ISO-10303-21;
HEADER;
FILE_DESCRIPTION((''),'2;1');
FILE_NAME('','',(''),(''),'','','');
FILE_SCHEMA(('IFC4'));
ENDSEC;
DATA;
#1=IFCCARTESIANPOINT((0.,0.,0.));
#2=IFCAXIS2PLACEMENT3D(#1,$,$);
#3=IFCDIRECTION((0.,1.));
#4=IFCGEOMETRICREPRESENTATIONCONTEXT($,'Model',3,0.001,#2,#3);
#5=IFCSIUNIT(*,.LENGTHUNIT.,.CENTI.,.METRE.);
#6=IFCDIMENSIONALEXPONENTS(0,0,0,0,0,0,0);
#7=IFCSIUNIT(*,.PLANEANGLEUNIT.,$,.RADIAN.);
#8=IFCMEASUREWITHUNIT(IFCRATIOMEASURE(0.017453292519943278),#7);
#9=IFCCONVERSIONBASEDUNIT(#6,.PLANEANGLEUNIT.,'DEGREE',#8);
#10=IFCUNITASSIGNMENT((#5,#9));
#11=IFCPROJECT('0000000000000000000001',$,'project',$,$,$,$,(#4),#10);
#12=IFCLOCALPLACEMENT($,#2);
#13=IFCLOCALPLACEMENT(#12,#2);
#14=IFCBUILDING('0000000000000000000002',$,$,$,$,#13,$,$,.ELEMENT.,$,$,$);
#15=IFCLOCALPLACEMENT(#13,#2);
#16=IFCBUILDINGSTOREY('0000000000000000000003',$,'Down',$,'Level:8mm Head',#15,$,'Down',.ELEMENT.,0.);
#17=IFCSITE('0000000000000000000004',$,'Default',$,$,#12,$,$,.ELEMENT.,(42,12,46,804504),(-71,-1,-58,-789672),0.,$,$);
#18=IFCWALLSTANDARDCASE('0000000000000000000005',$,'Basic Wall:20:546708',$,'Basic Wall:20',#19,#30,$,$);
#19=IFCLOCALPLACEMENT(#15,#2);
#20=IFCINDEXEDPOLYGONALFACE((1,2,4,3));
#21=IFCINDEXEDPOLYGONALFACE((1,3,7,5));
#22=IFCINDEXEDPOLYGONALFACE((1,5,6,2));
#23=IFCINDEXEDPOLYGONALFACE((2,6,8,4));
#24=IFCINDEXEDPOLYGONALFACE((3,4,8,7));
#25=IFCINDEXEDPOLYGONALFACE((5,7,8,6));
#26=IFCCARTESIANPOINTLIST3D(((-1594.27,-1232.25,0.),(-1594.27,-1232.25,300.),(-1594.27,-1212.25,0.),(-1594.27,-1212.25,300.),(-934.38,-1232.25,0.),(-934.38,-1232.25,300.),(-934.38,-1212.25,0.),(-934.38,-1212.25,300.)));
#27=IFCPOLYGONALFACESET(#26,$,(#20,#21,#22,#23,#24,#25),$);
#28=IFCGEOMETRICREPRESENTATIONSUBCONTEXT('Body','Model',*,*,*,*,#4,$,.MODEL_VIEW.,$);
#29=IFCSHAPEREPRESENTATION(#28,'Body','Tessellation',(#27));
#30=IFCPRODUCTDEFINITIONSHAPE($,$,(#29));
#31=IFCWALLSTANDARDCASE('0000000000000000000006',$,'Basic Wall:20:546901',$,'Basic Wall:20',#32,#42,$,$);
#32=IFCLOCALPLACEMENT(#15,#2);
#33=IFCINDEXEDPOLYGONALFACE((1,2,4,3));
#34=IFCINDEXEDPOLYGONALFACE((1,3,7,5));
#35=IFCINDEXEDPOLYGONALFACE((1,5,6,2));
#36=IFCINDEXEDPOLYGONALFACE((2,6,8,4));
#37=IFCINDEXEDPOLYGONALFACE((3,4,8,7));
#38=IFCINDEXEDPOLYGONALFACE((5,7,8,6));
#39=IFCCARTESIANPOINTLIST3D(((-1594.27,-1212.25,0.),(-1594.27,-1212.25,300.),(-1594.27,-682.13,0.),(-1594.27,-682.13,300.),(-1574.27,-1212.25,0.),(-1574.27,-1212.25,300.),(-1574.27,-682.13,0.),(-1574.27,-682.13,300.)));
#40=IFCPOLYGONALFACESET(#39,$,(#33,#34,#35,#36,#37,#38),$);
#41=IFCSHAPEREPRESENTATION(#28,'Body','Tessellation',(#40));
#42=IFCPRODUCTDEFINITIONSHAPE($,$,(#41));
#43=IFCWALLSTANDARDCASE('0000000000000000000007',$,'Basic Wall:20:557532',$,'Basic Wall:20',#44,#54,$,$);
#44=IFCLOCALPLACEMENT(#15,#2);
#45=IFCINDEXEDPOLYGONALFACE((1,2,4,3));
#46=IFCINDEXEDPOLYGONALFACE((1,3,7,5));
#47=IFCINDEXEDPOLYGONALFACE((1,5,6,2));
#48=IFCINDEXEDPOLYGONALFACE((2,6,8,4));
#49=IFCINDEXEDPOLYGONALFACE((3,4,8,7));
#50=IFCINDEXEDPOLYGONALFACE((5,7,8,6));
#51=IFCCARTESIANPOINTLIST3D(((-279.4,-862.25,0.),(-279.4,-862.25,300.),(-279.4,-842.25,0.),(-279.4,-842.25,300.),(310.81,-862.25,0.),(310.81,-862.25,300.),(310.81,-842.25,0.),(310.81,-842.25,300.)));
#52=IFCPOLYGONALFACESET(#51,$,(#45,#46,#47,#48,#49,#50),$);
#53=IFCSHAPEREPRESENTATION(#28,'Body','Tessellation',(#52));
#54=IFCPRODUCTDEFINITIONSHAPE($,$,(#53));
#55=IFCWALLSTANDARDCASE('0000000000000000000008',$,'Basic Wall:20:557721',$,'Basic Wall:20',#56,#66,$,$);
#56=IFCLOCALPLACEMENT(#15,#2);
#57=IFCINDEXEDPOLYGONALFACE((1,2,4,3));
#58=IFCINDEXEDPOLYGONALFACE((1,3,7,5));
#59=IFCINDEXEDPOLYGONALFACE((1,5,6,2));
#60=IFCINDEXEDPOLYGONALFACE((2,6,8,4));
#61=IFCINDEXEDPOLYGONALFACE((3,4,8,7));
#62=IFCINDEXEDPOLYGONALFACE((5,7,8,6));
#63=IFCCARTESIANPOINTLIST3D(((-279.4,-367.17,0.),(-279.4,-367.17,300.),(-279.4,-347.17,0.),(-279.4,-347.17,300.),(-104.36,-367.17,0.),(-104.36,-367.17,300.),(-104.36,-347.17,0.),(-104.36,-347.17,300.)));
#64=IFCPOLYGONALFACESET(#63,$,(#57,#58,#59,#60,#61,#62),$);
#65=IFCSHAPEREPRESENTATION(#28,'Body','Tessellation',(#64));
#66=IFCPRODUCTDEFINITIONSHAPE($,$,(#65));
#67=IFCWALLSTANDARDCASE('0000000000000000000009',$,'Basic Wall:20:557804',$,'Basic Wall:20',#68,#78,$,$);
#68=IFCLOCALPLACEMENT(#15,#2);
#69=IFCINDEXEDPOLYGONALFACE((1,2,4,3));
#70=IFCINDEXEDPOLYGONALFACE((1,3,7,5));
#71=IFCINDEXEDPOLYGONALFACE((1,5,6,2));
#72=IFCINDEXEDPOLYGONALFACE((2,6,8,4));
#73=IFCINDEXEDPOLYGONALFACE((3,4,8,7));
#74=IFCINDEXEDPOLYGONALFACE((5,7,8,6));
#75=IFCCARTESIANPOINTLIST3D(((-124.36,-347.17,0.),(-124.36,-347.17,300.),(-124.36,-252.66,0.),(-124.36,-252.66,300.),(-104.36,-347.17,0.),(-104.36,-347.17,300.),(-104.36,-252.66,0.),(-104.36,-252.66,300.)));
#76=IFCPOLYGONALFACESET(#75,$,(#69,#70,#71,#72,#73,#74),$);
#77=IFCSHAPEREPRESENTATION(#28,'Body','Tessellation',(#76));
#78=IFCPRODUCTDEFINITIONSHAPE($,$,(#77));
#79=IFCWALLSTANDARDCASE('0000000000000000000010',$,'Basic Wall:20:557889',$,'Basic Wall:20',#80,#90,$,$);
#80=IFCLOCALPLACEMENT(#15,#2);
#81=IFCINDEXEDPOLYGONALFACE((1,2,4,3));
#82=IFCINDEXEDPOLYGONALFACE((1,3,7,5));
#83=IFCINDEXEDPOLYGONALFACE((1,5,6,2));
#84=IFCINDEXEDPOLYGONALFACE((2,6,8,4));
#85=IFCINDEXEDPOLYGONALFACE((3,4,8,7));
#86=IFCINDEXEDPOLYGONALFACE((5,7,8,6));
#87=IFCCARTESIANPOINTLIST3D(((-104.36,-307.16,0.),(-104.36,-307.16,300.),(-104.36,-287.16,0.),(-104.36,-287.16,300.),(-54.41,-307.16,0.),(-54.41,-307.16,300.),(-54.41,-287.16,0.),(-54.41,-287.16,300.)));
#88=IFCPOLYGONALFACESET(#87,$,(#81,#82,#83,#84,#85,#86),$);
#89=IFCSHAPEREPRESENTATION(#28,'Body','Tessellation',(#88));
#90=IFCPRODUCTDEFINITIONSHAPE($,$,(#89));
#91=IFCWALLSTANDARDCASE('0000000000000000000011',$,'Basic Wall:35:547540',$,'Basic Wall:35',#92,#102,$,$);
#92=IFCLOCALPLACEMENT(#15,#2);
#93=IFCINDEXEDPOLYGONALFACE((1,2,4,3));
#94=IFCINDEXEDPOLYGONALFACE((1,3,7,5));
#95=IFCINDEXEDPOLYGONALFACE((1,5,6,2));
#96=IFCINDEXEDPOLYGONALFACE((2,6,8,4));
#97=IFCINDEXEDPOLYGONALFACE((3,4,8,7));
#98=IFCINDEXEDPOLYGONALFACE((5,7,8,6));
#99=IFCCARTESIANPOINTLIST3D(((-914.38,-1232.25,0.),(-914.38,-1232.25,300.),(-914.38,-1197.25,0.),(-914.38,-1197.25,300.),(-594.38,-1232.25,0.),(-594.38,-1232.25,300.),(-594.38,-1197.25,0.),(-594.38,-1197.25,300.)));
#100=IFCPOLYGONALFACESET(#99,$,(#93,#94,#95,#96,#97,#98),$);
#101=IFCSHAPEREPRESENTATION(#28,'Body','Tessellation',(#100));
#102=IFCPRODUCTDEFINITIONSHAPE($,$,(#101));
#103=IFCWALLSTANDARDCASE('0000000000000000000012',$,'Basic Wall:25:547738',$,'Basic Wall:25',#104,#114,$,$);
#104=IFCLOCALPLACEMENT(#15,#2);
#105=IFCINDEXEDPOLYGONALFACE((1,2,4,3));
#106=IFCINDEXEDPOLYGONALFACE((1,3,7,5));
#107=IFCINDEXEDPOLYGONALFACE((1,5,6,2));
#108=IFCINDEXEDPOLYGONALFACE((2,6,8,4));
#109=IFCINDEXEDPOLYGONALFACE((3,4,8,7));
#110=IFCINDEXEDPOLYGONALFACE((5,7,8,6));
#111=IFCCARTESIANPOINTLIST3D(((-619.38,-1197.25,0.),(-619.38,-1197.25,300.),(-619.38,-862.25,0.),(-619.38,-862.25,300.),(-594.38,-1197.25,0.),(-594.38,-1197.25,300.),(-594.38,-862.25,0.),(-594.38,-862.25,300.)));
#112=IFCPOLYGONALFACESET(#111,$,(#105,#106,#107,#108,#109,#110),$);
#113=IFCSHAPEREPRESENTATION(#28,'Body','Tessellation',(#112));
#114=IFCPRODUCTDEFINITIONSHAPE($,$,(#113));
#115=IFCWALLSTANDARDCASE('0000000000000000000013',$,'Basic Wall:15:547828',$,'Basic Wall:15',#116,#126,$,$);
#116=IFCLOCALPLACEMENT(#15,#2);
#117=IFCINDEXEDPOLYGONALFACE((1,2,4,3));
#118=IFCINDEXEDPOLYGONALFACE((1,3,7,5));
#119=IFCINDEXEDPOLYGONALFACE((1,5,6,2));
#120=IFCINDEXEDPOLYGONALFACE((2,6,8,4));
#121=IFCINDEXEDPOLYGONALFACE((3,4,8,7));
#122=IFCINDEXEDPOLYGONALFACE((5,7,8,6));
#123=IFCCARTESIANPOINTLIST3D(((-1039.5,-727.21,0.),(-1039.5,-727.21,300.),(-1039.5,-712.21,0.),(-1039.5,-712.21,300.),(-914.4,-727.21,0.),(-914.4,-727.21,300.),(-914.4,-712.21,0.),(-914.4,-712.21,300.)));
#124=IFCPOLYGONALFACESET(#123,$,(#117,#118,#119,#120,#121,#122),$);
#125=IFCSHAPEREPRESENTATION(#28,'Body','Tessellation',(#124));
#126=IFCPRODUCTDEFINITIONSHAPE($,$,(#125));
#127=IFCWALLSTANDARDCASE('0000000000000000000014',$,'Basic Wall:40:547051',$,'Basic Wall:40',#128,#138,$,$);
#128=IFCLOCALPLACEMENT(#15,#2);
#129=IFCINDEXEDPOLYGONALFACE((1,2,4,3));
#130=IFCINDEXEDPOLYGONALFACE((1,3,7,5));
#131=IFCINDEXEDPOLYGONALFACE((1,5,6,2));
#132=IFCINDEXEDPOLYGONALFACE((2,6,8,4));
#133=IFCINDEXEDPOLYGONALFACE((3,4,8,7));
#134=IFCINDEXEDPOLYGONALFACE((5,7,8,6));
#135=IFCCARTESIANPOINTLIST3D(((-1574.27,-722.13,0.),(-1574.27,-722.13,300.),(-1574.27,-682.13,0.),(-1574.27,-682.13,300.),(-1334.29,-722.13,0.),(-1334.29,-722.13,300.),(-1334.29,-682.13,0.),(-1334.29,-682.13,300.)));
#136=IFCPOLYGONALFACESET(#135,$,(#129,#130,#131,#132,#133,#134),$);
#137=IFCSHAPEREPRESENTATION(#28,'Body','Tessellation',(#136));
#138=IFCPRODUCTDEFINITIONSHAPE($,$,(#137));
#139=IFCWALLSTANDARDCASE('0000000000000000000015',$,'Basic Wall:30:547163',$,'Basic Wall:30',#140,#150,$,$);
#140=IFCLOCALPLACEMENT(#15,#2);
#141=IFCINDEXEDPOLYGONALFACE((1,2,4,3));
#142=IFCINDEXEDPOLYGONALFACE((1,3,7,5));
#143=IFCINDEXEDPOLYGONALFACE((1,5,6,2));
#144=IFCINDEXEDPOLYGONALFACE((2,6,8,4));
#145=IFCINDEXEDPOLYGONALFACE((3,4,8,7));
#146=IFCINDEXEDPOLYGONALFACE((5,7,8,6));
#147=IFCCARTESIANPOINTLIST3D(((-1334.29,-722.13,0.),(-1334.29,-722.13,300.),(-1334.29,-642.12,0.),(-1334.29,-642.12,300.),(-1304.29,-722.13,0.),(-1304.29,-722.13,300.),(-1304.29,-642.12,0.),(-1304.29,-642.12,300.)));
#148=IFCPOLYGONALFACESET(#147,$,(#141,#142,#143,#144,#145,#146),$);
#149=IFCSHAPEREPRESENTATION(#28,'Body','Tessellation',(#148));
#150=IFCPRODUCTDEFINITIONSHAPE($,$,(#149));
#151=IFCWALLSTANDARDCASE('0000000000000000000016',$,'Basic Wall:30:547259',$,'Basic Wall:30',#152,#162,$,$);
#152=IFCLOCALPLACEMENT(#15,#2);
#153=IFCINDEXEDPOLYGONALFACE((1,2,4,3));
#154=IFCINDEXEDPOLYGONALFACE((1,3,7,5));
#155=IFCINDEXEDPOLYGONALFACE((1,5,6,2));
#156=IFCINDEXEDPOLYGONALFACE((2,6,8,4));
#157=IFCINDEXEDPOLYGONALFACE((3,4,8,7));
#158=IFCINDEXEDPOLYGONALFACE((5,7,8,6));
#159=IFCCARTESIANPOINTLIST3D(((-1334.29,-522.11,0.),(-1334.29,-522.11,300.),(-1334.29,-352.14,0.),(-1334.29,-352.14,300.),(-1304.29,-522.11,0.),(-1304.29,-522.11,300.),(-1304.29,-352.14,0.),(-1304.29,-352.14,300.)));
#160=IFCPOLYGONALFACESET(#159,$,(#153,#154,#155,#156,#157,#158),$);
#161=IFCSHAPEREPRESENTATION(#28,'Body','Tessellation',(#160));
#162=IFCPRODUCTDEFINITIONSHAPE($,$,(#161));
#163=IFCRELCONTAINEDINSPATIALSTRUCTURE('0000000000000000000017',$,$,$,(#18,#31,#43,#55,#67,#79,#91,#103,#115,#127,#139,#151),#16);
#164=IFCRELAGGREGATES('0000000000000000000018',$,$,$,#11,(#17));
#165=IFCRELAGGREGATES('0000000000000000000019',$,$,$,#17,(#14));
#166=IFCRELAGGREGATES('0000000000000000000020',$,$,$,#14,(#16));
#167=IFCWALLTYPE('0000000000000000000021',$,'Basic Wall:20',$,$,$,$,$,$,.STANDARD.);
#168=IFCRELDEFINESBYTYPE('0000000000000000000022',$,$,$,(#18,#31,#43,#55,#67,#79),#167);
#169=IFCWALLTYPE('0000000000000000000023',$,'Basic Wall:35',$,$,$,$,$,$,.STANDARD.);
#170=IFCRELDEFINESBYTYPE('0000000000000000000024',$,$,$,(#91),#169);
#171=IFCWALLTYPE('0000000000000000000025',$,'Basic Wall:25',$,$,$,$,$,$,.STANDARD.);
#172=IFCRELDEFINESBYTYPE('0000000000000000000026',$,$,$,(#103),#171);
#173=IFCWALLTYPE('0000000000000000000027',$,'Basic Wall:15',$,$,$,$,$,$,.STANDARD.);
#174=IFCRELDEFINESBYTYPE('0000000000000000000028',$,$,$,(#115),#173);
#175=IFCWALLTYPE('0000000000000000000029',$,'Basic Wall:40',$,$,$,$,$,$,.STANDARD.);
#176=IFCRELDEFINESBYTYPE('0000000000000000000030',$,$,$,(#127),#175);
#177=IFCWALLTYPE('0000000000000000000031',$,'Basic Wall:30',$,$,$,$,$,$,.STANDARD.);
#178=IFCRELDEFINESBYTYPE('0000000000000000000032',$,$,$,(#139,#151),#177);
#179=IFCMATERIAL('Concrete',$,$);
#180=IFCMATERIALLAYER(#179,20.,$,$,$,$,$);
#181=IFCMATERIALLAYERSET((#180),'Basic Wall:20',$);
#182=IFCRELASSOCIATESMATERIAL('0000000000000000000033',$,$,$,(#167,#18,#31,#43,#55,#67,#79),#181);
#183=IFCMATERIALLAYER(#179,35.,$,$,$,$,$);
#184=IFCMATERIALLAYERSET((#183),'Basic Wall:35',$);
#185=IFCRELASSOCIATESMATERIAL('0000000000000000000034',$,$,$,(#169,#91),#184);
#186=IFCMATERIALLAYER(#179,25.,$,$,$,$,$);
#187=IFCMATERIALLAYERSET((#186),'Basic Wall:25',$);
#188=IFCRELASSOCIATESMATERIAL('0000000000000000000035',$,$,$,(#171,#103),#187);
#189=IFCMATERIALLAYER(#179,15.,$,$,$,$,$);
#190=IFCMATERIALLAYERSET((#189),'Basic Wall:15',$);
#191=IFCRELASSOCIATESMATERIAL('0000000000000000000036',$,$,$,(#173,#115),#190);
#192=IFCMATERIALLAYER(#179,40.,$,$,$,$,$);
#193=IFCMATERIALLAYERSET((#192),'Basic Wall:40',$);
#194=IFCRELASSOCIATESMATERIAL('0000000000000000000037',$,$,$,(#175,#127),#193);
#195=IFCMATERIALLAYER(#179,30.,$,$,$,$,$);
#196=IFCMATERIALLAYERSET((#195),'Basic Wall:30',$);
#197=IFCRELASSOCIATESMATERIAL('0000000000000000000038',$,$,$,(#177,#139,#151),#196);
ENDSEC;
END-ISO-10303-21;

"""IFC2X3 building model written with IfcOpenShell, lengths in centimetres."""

from ifc_helpers import new_model, entity, si_unit, converted_unit, direction, frame, frame_2d, origin, place, context, subcontext, project, spatial, rectangle, extrude, material, layer, layer_set, layer_usage, type_object, element, save


model = new_model("IFC2X3")

# Units and contexts
model_context = context("Model", 3, precision=0.001, world=origin(), true_north=direction((0.0, 1.0)))
body_context = subcontext(model_context, "Body", "Model", "MODEL_VIEW")
ifc_project = project(units=[si_unit("LENGTHUNIT", "METRE", prefix="CENTI"), converted_unit("PLANEANGLEUNIT", "DEGREE", entity("IfcRatioMeasure", 0.017453292519943278), si_unit("PLANEANGLEUNIT", "RADIAN"), dimensions=[0, 0, 0, 0, 0, 0, 0])], contexts=[model_context])

# Site, building, storey
site_placement = place(None, origin())
site = spatial("IfcSite", under=ifc_project, at=site_placement, Name="Default", CompositionType="ELEMENT", RefLatitude=(42, 12, 46, 804504), RefLongitude=(-71, -1, -58, -789672), RefElevation=0.0)
building_placement = place(site_placement, origin())
building = spatial("IfcBuilding", under=site, at=building_placement, CompositionType="ELEMENT")
storey_placement = place(building_placement, origin())
storey = spatial("IfcBuildingStorey", under=building, at=storey_placement, Name="Down", ObjectType="Level:8mm Head", LongName="Down", CompositionType="ELEMENT", Elevation=0.0)

# Walls
ifc_material = material(Name="Concrete")
ifc_layer_1 = layer(ifc_material, 20.0)
ifc_layer_set_1 = layer_set([ifc_layer_1], Name="Basic Wall:20")
wall_type_1 = type_object("IfcWallType", Name="Basic Wall:20", PredefinedType="STANDARD", material=ifc_layer_set_1)
ifc_layer_usage_1 = layer_usage(ifc_layer_set_1, "AXIS2", "NEGATIVE", 10.0)
wall_1_placement = place(storey_placement, frame((-934.38, -1222.25, 0.0), z_axis=(0.0, 0.0, 1.0), x_axis=(-1.0, 0.0, 0.0)))
element("IfcWallStandardCase", 1, at=wall_1_placement, inside=storey, type_object=wall_type_1, material=ifc_layer_usage_1, Name="Basic Wall:20:546708", ObjectType="Basic Wall:20", context=body_context, shape_type="SweptSolid", body=[
    extrude(rectangle(XDim=659.89, YDim=20.0, at=frame_2d((329.95, 0.0), x_axis=(-1.0, 0.0))), origin(), (0.0, 0.0, 1.0), 300.0),
])
ifc_layer_usage_2 = layer_usage(ifc_layer_set_1, "AXIS2", "NEGATIVE", 10.0)
wall_2_placement = place(storey_placement, frame((-1584.27, -1212.25, 0.0), z_axis=(0.0, 0.0, 1.0), x_axis=(0.0, 1.0, 0.0)))
element("IfcWallStandardCase", 2, at=wall_2_placement, inside=storey, type_object=wall_type_1, material=ifc_layer_usage_2, Name="Basic Wall:20:546901", ObjectType="Basic Wall:20", context=body_context, shape_type="SweptSolid", body=[
    extrude(rectangle(XDim=530.12, YDim=20.0, at=frame_2d((265.06, 0.0), x_axis=(-1.0, 0.0))), origin(), (0.0, 0.0, 1.0), 300.0),
])
ifc_layer_usage_3 = layer_usage(ifc_layer_set_1, "AXIS2", "POSITIVE", -10.0)
wall_3_placement = place(storey_placement, frame((-279.4, -852.25, 0.0)))
element("IfcWallStandardCase", 3, at=wall_3_placement, inside=storey, type_object=wall_type_1, material=ifc_layer_usage_3, Name="Basic Wall:20:557532", ObjectType="Basic Wall:20", context=body_context, shape_type="SweptSolid", body=[
    extrude(rectangle(XDim=590.21, YDim=20.0, at=frame_2d((295.1, 0.0), x_axis=(-1.0, 0.0))), origin(), (0.0, 0.0, 1.0), 300.0),
])
ifc_layer_usage_4 = layer_usage(ifc_layer_set_1, "AXIS2", "POSITIVE", -10.0)
wall_4_placement = place(storey_placement, frame((-279.4, -357.17, 0.0)))
element("IfcWallStandardCase", 4, at=wall_4_placement, inside=storey, type_object=wall_type_1, material=ifc_layer_usage_4, Name="Basic Wall:20:557721", ObjectType="Basic Wall:20", context=body_context, shape_type="SweptSolid", body=[
    extrude(rectangle(XDim=175.04, YDim=20.0, at=frame_2d((87.52, 0.0), x_axis=(-1.0, 0.0))), origin(), (0.0, 0.0, 1.0), 300.0),
])
ifc_layer_usage_5 = layer_usage(ifc_layer_set_1, "AXIS2", "POSITIVE", -10.0)
wall_5_placement = place(storey_placement, frame((-114.36, -347.17, 0.0), z_axis=(0.0, 0.0, 1.0), x_axis=(0.0, 1.0, 0.0)))
element("IfcWallStandardCase", 5, at=wall_5_placement, inside=storey, type_object=wall_type_1, material=ifc_layer_usage_5, Name="Basic Wall:20:557804", ObjectType="Basic Wall:20", context=body_context, shape_type="SweptSolid", body=[
    extrude(rectangle(XDim=94.51, YDim=20.0, at=frame_2d((47.25, 0.0), x_axis=(-1.0, 0.0))), origin(), (0.0, 0.0, 1.0), 300.0),
])
ifc_layer_usage_6 = layer_usage(ifc_layer_set_1, "AXIS2", "NEGATIVE", 10.0)
wall_6_placement = place(storey_placement, frame((-104.36, -297.16, 0.0)))
element("IfcWallStandardCase", 6, at=wall_6_placement, inside=storey, type_object=wall_type_1, material=ifc_layer_usage_6, Name="Basic Wall:20:557889", ObjectType="Basic Wall:20", context=body_context, shape_type="SweptSolid", body=[
    extrude(rectangle(XDim=49.95, YDim=20.0, at=frame_2d((24.98, 0.0), x_axis=(-1.0, 0.0))), origin(), (0.0, 0.0, 1.0), 300.0),
])
ifc_layer_2 = layer(ifc_material, 35.0)
ifc_layer_set_2 = layer_set([ifc_layer_2], Name="Basic Wall:35")
ifc_layer_usage_7 = layer_usage(ifc_layer_set_2, "AXIS2", "POSITIVE", -17.5)
wall_type_2 = type_object("IfcWallType", Name="Basic Wall:35", PredefinedType="STANDARD", material=ifc_layer_set_2)
wall_7_placement = place(storey_placement, frame((-914.38, -1214.75, 0.0)))
element("IfcWallStandardCase", 7, at=wall_7_placement, inside=storey, type_object=wall_type_2, material=ifc_layer_usage_7, Name="Basic Wall:35:547540", ObjectType="Basic Wall:35", context=body_context, shape_type="SweptSolid", body=[
    extrude(rectangle(XDim=320.0, YDim=35.0, at=frame_2d((160.0, 0.0), x_axis=(-1.0, 0.0))), origin(), (0.0, 0.0, 1.0), 300.0),
])
ifc_layer_3 = layer(ifc_material, 25.0)
ifc_layer_set_3 = layer_set([ifc_layer_3], Name="Basic Wall:25")
ifc_layer_usage_8 = layer_usage(ifc_layer_set_3, "AXIS2", "POSITIVE", -12.5)
wall_type_3 = type_object("IfcWallType", Name="Basic Wall:25", PredefinedType="STANDARD", material=ifc_layer_set_3)
wall_8_placement = place(storey_placement, frame((-606.88, -1197.25, 0.0), z_axis=(0.0, 0.0, 1.0), x_axis=(0.0, 1.0, 0.0)))
element("IfcWallStandardCase", 8, at=wall_8_placement, inside=storey, type_object=wall_type_3, material=ifc_layer_usage_8, Name="Basic Wall:25:547738", ObjectType="Basic Wall:25", context=body_context, shape_type="SweptSolid", body=[
    extrude(rectangle(XDim=334.99, YDim=25.0, at=frame_2d((167.5, 0.0), x_axis=(-1.0, 0.0))), origin(), (0.0, 0.0, 1.0), 300.0),
])
ifc_layer_4 = layer(ifc_material, 15.0)
ifc_layer_set_4 = layer_set([ifc_layer_4], Name="Basic Wall:15")
ifc_layer_usage_9 = layer_usage(ifc_layer_set_4, "AXIS2", "POSITIVE", -7.5)
wall_type_4 = type_object("IfcWallType", Name="Basic Wall:15", PredefinedType="STANDARD", material=ifc_layer_set_4)
wall_9_placement = place(storey_placement, frame((-1039.5, -719.71, 0.0)))
element("IfcWallStandardCase", 9, at=wall_9_placement, inside=storey, type_object=wall_type_4, material=ifc_layer_usage_9, Name="Basic Wall:15:547828", ObjectType="Basic Wall:15", context=body_context, shape_type="SweptSolid", body=[
    extrude(rectangle(XDim=125.09, YDim=15.0, at=frame_2d((62.55, 0.0), x_axis=(-1.0, 0.0))), origin(), (0.0, 0.0, 1.0), 300.0),
])
ifc_layer_5 = layer(ifc_material, 40.0)
ifc_layer_set_5 = layer_set([ifc_layer_5], Name="Basic Wall:40")
ifc_layer_usage_10 = layer_usage(ifc_layer_set_5, "AXIS2", "NEGATIVE", 20.0)
wall_type_5 = type_object("IfcWallType", Name="Basic Wall:40", PredefinedType="STANDARD", material=ifc_layer_set_5)
wall_10_placement = place(storey_placement, frame((-1574.27, -702.13, 0.0)))
element("IfcWallStandardCase", 10, at=wall_10_placement, inside=storey, type_object=wall_type_5, material=ifc_layer_usage_10, Name="Basic Wall:40:547051", ObjectType="Basic Wall:40", context=body_context, shape_type="SweptSolid", body=[
    extrude(rectangle(XDim=239.98, YDim=40.0, at=frame_2d((119.99, 0.0), x_axis=(-1.0, 0.0))), origin(), (0.0, 0.0, 1.0), 300.0),
])
ifc_layer_6 = layer(ifc_material, 30.0)
ifc_layer_set_6 = layer_set([ifc_layer_6], Name="Basic Wall:30")
ifc_layer_usage_11 = layer_usage(ifc_layer_set_6, "AXIS2", "POSITIVE", -15.0)
wall_type_6 = type_object("IfcWallType", Name="Basic Wall:30", PredefinedType="STANDARD", material=ifc_layer_set_6)
wall_11_placement = place(storey_placement, frame((-1319.29, -722.13, 0.0), z_axis=(0.0, 0.0, 1.0), x_axis=(0.0, 1.0, 0.0)))
element("IfcWallStandardCase", 11, at=wall_11_placement, inside=storey, type_object=wall_type_6, material=ifc_layer_usage_11, Name="Basic Wall:30:547163", ObjectType="Basic Wall:30", context=body_context, shape_type="SweptSolid", body=[
    extrude(rectangle(XDim=80.0, YDim=30.0, at=frame_2d((40.0, 0.0), x_axis=(-1.0, 0.0))), origin(), (0.0, 0.0, 1.0), 300.0),
])
ifc_layer_usage_12 = layer_usage(ifc_layer_set_6, "AXIS2", "POSITIVE", -15.0)
wall_12_placement = place(storey_placement, frame((-1319.29, -522.11, 0.0), z_axis=(0.0, 0.0, 1.0), x_axis=(0.0, 1.0, 0.0)))
element("IfcWallStandardCase", 12, at=wall_12_placement, inside=storey, type_object=wall_type_6, material=ifc_layer_usage_12, Name="Basic Wall:30:547259", ObjectType="Basic Wall:30", context=body_context, shape_type="SweptSolid", body=[
    extrude(rectangle(XDim=169.97, YDim=30.0, at=frame_2d((84.98, 0.0), x_axis=(-1.0, 0.0))), origin(), (0.0, 0.0, 1.0), 300.0),
])

save(model, "model.ifc")
